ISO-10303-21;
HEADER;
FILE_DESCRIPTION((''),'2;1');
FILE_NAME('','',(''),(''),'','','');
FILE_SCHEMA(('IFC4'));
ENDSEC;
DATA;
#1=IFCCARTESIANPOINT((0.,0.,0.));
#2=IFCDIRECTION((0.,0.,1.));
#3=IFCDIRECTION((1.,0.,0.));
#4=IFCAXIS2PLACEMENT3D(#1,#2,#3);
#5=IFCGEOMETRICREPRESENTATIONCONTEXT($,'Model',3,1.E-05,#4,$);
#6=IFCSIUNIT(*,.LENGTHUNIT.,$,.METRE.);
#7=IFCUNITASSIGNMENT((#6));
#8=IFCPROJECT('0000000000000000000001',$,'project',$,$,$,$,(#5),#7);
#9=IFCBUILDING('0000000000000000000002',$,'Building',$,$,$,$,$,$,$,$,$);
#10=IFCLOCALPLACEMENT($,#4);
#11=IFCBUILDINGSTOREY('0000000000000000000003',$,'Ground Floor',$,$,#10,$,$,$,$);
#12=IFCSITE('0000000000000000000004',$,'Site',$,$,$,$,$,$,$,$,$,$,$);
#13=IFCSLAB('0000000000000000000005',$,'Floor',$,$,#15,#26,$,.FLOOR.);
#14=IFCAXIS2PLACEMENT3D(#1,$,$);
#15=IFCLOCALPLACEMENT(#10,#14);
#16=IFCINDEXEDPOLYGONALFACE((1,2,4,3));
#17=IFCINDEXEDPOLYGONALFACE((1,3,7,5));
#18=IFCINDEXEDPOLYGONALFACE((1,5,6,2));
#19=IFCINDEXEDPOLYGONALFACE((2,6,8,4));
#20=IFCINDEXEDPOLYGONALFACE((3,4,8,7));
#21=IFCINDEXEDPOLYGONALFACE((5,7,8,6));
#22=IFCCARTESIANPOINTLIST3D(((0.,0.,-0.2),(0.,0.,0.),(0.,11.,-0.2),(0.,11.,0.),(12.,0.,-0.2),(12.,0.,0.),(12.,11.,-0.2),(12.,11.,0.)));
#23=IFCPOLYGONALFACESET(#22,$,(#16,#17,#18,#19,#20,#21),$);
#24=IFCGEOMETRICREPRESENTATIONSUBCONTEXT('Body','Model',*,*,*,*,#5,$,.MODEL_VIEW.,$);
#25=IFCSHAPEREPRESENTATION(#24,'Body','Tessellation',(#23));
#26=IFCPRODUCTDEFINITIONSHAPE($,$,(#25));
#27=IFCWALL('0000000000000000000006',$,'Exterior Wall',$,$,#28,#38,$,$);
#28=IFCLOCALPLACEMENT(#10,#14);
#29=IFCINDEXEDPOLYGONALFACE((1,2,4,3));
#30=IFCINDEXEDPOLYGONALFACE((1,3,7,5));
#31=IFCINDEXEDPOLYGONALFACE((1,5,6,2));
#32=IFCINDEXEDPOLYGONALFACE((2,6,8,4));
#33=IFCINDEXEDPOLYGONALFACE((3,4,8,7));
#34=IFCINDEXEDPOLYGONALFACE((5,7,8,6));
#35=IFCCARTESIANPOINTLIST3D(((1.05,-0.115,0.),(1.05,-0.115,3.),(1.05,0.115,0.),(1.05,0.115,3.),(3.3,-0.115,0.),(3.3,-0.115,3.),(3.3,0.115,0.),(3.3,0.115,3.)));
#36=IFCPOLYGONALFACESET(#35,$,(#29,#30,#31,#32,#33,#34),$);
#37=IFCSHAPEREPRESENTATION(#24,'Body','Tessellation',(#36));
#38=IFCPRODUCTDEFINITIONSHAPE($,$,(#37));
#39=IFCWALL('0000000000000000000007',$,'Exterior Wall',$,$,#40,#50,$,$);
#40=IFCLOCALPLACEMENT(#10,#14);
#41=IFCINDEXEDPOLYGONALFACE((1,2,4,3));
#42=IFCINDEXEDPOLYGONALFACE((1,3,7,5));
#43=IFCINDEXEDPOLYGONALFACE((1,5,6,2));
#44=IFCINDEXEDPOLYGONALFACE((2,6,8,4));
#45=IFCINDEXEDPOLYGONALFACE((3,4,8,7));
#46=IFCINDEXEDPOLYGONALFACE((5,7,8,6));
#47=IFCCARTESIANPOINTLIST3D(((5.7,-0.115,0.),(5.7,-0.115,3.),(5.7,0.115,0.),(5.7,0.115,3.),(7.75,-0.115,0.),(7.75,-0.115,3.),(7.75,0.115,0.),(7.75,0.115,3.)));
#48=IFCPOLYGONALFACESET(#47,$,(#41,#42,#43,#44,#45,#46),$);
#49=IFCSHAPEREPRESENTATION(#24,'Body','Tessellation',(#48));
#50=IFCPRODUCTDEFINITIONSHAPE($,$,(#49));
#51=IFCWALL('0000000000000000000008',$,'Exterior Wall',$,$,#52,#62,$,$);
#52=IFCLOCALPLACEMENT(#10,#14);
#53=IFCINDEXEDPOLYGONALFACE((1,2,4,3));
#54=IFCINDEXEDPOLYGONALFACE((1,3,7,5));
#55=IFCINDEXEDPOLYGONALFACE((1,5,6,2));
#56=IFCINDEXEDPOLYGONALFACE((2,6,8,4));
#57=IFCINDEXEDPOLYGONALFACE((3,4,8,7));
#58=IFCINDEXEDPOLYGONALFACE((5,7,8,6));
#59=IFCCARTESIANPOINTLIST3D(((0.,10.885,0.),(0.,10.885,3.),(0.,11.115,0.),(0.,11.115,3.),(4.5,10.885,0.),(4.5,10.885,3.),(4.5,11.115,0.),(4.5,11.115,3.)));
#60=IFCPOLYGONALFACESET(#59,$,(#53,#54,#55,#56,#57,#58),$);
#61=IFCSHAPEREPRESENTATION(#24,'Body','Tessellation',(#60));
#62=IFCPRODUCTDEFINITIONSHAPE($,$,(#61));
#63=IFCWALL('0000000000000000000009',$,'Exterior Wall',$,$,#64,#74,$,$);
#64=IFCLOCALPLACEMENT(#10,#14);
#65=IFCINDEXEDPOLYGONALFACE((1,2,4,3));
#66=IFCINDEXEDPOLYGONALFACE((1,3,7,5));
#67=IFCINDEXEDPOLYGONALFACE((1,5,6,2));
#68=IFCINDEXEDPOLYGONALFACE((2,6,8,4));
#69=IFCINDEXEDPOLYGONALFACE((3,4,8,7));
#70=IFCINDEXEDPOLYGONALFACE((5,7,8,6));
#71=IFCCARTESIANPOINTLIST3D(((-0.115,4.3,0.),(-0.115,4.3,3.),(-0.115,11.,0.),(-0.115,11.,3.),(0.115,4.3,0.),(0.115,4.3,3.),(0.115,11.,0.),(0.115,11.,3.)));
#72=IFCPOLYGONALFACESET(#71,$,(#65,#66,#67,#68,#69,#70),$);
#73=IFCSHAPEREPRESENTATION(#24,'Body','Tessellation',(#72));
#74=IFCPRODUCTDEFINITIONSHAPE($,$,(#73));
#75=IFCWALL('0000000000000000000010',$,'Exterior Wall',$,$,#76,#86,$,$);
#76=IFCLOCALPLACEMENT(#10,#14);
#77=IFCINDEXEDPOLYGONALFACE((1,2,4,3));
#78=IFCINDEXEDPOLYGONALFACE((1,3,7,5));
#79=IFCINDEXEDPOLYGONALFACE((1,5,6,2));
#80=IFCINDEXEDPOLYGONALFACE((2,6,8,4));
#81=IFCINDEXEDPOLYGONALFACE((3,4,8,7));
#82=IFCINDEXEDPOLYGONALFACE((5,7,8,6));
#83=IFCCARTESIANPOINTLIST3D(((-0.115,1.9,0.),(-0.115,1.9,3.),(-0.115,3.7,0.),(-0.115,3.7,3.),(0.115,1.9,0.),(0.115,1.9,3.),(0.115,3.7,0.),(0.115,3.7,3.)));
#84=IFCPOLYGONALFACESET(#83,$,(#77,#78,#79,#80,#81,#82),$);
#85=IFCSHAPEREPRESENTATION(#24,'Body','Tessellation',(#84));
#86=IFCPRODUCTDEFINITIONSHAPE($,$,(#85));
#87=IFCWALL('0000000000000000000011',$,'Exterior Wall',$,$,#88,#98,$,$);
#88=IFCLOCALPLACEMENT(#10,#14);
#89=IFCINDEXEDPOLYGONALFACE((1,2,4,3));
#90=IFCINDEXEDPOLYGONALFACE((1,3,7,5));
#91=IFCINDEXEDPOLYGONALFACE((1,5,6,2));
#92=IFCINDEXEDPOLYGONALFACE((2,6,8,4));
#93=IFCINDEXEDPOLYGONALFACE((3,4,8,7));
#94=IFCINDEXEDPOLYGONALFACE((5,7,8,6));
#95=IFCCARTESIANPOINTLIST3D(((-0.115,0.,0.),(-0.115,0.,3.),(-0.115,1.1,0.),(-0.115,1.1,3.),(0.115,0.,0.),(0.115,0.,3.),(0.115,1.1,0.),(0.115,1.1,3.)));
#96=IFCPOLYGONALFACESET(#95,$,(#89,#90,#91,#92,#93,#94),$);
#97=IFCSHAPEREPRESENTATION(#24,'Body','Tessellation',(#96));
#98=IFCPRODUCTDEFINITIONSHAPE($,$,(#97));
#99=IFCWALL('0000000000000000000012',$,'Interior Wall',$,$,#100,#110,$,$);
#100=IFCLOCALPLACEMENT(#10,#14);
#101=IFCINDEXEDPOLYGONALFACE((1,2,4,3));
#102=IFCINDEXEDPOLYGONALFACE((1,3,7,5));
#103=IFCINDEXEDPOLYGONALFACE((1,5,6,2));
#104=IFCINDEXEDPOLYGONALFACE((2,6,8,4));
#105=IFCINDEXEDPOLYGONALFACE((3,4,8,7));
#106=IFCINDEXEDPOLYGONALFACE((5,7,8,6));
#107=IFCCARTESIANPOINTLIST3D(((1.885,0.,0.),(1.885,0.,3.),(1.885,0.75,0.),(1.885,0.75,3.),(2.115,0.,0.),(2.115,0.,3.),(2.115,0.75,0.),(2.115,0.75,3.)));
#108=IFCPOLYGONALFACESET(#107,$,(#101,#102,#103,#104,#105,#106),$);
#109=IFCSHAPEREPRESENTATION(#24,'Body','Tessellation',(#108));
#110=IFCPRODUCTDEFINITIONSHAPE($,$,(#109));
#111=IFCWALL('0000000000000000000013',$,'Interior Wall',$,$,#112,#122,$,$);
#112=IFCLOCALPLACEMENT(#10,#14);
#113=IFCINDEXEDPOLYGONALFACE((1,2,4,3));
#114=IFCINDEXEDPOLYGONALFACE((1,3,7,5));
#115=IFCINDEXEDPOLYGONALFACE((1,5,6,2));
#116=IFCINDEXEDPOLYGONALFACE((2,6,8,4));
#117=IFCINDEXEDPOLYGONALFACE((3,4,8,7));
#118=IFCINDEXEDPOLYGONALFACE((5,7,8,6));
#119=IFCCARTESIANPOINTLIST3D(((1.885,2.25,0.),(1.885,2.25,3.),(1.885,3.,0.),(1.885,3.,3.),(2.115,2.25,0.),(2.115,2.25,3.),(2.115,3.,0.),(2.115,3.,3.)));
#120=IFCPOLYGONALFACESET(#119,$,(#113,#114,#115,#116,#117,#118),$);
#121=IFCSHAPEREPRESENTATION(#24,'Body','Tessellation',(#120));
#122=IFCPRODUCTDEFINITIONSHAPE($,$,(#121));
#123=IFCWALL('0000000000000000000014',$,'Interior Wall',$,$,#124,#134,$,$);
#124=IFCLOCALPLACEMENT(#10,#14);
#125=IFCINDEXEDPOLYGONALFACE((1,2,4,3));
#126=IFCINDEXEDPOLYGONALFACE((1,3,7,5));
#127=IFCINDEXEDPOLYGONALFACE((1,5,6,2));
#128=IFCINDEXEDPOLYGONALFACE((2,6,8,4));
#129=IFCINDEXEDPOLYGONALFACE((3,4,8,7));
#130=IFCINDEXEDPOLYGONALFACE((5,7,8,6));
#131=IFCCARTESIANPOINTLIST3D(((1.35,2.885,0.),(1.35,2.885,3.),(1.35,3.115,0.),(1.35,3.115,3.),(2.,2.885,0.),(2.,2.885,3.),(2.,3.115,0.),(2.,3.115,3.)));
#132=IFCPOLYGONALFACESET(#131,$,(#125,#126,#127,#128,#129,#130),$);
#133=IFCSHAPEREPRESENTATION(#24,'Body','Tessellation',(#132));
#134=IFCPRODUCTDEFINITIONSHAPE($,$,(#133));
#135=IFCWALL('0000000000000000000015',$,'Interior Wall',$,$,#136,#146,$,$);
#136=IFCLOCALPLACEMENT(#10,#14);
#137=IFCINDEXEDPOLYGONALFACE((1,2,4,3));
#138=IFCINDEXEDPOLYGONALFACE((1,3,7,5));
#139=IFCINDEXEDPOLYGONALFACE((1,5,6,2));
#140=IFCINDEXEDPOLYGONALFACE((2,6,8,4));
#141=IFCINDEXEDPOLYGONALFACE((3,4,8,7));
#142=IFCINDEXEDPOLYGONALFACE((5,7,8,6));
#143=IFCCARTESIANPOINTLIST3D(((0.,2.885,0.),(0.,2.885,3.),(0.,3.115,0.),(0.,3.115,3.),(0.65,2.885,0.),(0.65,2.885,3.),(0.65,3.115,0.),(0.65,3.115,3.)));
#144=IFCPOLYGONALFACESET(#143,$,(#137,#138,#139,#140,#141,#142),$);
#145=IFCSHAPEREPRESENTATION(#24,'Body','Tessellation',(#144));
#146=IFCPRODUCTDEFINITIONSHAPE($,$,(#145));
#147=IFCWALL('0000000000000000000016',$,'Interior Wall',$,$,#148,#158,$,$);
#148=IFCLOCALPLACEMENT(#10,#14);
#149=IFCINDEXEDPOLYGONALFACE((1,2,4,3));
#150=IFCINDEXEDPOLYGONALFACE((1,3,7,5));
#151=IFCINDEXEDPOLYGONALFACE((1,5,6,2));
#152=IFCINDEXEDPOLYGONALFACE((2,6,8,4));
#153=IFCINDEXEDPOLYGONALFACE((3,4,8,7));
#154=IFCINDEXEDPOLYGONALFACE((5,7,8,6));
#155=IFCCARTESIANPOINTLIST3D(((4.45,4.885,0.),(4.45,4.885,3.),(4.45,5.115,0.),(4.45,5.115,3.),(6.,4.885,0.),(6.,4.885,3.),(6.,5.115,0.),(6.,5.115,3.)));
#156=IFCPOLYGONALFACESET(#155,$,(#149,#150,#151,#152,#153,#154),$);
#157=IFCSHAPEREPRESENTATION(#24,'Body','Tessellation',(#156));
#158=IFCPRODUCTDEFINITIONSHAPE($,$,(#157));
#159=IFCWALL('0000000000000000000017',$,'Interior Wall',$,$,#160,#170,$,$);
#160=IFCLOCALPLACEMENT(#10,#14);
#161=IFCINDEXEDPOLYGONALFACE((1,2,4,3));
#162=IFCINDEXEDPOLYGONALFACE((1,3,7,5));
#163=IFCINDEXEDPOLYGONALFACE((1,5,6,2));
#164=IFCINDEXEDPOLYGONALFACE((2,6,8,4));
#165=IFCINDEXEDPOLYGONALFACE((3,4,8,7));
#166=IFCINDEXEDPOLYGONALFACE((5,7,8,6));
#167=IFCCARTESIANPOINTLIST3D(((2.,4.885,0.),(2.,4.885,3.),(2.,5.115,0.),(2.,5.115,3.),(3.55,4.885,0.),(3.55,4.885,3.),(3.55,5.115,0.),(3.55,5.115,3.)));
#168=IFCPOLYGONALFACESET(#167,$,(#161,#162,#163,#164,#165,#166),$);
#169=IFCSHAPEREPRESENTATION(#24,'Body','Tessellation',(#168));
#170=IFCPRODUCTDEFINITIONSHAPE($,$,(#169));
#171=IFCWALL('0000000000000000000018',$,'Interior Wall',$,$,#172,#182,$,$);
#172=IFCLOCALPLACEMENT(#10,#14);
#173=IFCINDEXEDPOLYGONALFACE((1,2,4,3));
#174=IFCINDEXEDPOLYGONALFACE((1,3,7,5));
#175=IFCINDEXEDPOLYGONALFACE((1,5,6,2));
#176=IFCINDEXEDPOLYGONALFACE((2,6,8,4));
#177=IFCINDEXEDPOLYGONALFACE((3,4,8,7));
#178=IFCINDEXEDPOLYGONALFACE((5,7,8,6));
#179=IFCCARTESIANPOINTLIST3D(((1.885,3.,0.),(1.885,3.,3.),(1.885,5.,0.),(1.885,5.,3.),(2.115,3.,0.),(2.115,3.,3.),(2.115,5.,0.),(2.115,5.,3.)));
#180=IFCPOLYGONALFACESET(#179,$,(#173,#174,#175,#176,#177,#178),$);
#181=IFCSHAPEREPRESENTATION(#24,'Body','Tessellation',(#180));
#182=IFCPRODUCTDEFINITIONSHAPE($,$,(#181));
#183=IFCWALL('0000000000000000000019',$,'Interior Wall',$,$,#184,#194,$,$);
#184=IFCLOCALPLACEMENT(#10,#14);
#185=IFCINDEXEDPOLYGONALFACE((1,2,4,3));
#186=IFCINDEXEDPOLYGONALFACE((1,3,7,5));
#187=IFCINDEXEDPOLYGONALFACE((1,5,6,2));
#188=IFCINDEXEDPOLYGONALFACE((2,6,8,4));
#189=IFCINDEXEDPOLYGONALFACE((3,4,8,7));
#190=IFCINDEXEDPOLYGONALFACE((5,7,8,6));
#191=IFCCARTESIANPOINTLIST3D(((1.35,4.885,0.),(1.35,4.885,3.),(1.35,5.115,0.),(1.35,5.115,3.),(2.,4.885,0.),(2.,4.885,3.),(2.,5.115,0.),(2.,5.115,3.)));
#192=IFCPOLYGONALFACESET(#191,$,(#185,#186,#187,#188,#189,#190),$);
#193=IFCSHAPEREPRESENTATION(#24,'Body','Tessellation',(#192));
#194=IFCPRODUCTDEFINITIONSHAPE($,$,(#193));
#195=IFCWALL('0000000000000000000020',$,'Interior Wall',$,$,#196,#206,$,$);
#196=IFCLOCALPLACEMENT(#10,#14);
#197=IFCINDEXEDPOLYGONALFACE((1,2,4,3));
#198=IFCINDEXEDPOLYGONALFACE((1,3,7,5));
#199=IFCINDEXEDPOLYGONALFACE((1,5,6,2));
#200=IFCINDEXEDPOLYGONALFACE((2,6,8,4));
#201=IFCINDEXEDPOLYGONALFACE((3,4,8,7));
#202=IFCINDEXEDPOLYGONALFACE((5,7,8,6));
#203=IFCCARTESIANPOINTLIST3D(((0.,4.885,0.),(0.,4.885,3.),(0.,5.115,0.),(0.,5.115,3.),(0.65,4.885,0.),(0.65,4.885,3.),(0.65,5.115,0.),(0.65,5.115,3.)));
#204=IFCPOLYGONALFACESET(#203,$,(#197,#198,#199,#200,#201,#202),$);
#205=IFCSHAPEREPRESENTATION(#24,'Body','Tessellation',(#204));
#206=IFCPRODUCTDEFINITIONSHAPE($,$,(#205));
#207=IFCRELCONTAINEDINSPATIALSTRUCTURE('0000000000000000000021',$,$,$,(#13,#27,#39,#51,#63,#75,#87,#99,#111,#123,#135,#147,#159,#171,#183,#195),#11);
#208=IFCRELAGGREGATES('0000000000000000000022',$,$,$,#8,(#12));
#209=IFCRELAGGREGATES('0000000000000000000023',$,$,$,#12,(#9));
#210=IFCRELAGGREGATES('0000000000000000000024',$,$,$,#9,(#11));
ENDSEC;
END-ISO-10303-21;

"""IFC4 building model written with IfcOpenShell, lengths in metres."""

from ifc_helpers import new_model, si_unit, frame, origin_with_axes, place, context, subcontext, project, spatial, indexed_curve, outline, extrude, element, save


model = new_model("IFC4")

# Units and contexts
model_context = context("Model", 3, precision=1e-05, world=origin_with_axes())
body_context = subcontext(model_context, "Body", "Model", "MODEL_VIEW")
ifc_project = project(units=[si_unit("LENGTHUNIT", "METRE")], contexts=[model_context])

# Site, building, storey
site = spatial("IfcSite", under=ifc_project, Name="Site")
building = spatial("IfcBuilding", under=site, Name="Building")
storey_placement = place(None, origin_with_axes())
storey = spatial("IfcBuildingStorey", under=building, at=storey_placement, Name="Ground Floor")

# Slab
slab_placement = place(storey_placement, frame((0.0, 0.0, -0.2), z_axis=(0.0, 0.0, 1.0), x_axis=(1.0, 0.0, 0.0)))
element("IfcSlab", 1, at=slab_placement, inside=storey, Name="Floor", PredefinedType="FLOOR", context=body_context, shape_type="SweptSolid", body=[
    extrude(outline(indexed_curve([(0.0, 0.0), (12.0, 0.0), (12.0, 11.0), (0.0, 11.0)])), None, (0.0, 0.0, 1.0), 0.2),
])

# Walls
wall_1_placement = place(storey_placement, frame((1.05, 0.0, 0.0), z_axis=(0.0, 0.0, 1.0), x_axis=(1.0, 0.0, 0.0)))
element("IfcWall", 2, at=wall_1_placement, inside=storey, Name="Exterior Wall", context=body_context, shape_type="SweptSolid", body=[
    extrude(outline(indexed_curve([(0.0, 0.0), (0.0, 0.23), (2.25, 0.23), (2.25, 0.0), (0.0, 0.0)], self_intersect=False)), frame((0.0, -0.115, 0.0), z_axis=(0.0, 0.0, 1.0), x_axis=(1.0, 0.0, 0.0)), (0.0, 0.0, 1.0), 3.0),
])
wall_2_placement = place(storey_placement, frame((5.7, 0.0, 0.0), z_axis=(0.0, 0.0, 1.0), x_axis=(1.0, 0.0, 0.0)))
element("IfcWall", 3, at=wall_2_placement, inside=storey, Name="Exterior Wall", context=body_context, shape_type="SweptSolid", body=[
    extrude(outline(indexed_curve([(0.0, 0.0), (0.0, 0.23), (2.05, 0.23), (2.05, 0.0), (0.0, 0.0)], self_intersect=False)), frame((0.0, -0.115, 0.0), z_axis=(0.0, 0.0, 1.0), x_axis=(1.0, 0.0, 0.0)), (0.0, 0.0, 1.0), 3.0),
])
wall_3_placement = place(storey_placement, frame((4.5, 11.0, 0.0), z_axis=(0.0, 0.0, 1.0), x_axis=(-1.0, 0.0, 0.0)))
element("IfcWall", 4, at=wall_3_placement, inside=storey, Name="Exterior Wall", context=body_context, shape_type="SweptSolid", body=[
    extrude(outline(indexed_curve([(0.0, 0.0), (0.0, 0.23), (4.5, 0.23), (4.5, 0.0), (0.0, 0.0)], self_intersect=False)), frame((0.0, -0.115, 0.0), z_axis=(0.0, 0.0, 1.0), x_axis=(1.0, 0.0, 0.0)), (0.0, 0.0, 1.0), 3.0),
])
wall_4_placement = place(storey_placement, frame((0.0, 11.0, 0.0), z_axis=(0.0, 0.0, 1.0), x_axis=(0.0, -1.0, 0.0)))
element("IfcWall", 5, at=wall_4_placement, inside=storey, Name="Exterior Wall", context=body_context, shape_type="SweptSolid", body=[
    extrude(outline(indexed_curve([(0.0, 0.0), (0.0, 0.23), (6.7, 0.23), (6.7, 0.0), (0.0, 0.0)], self_intersect=False)), frame((0.0, -0.115, 0.0), z_axis=(0.0, 0.0, 1.0), x_axis=(1.0, 0.0, 0.0)), (0.0, 0.0, 1.0), 3.0),
])
wall_5_placement = place(storey_placement, frame((0.0, 3.7, 0.0), z_axis=(0.0, 0.0, 1.0), x_axis=(0.0, -1.0, 0.0)))
element("IfcWall", 6, at=wall_5_placement, inside=storey, Name="Exterior Wall", context=body_context, shape_type="SweptSolid", body=[
    extrude(outline(indexed_curve([(0.0, 0.0), (0.0, 0.23), (1.8, 0.23), (1.8, 0.0), (0.0, 0.0)], self_intersect=False)), frame((0.0, -0.115, 0.0), z_axis=(0.0, 0.0, 1.0), x_axis=(1.0, 0.0, 0.0)), (0.0, 0.0, 1.0), 3.0),
])
wall_6_placement = place(storey_placement, frame((0.0, 1.1, 0.0), z_axis=(0.0, 0.0, 1.0), x_axis=(0.0, -1.0, 0.0)))
element("IfcWall", 7, at=wall_6_placement, inside=storey, Name="Exterior Wall", context=body_context, shape_type="SweptSolid", body=[
    extrude(outline(indexed_curve([(0.0, 0.0), (0.0, 0.23), (1.1, 0.23), (1.1, 0.0), (0.0, 0.0)], self_intersect=False)), frame((0.0, -0.115, 0.0), z_axis=(0.0, 0.0, 1.0), x_axis=(1.0, 0.0, 0.0)), (0.0, 0.0, 1.0), 3.0),
])
for number, where, z_axis, x_axis, name in (
    (8, (2.0, 0.0, 0.0), (0.0, 0.0, 1.0), (0.0, 1.0, 0.0), "Interior Wall"),
    (9, (2.0, 2.25, 0.0), (0.0, 0.0, 1.0), (0.0, 1.0, 0.0), "Interior Wall"),
):
    element("IfcWall", number, at=place(storey_placement, frame(where, z_axis=z_axis, x_axis=x_axis)), inside=storey, Name=name, context=body_context, shape_type="SweptSolid", body=[
        extrude(outline(indexed_curve([(0.0, 0.0), (0.0, 0.23), (0.75, 0.23), (0.75, 0.0), (0.0, 0.0)], self_intersect=False)), frame((0.0, -0.115, 0.0), z_axis=(0.0, 0.0, 1.0), x_axis=(1.0, 0.0, 0.0)), (0.0, 0.0, 1.0), 3.0),
    ])
for number, where, z_axis, x_axis, name in (
    (10, (2.0, 3.0, 0.0), (0.0, 0.0, 1.0), (-1.0, 0.0, 0.0), "Interior Wall"),
    (11, (0.65, 3.0, 0.0), (0.0, 0.0, 1.0), (-1.0, 0.0, 0.0), "Interior Wall"),
):
    element("IfcWall", number, at=place(storey_placement, frame(where, z_axis=z_axis, x_axis=x_axis)), inside=storey, Name=name, context=body_context, shape_type="SweptSolid", body=[
        extrude(outline(indexed_curve([(0.0, 0.0), (0.0, 0.23), (0.65, 0.23), (0.65, 0.0), (0.0, 0.0)], self_intersect=False)), frame((0.0, -0.115, 0.0), z_axis=(0.0, 0.0, 1.0), x_axis=(1.0, 0.0, 0.0)), (0.0, 0.0, 1.0), 3.0),
    ])
for number, where, z_axis, x_axis, name in (
    (12, (6.0, 5.0, 0.0), (0.0, 0.0, 1.0), (-1.0, 0.0, 0.0), "Interior Wall"),
    (13, (3.55, 5.0, 0.0), (0.0, 0.0, 1.0), (-1.0, 0.0, 0.0), "Interior Wall"),
):
    element("IfcWall", number, at=place(storey_placement, frame(where, z_axis=z_axis, x_axis=x_axis)), inside=storey, Name=name, context=body_context, shape_type="SweptSolid", body=[
        extrude(outline(indexed_curve([(0.0, 0.0), (0.0, 0.23), (1.55, 0.23), (1.55, 0.0), (0.0, 0.0)], self_intersect=False)), frame((0.0, -0.115, 0.0), z_axis=(0.0, 0.0, 1.0), x_axis=(1.0, 0.0, 0.0)), (0.0, 0.0, 1.0), 3.0),
    ])
wall_7_placement = place(storey_placement, frame((2.0, 5.0, 0.0), z_axis=(0.0, 0.0, 1.0), x_axis=(0.0, -1.0, 0.0)))
element("IfcWall", 14, at=wall_7_placement, inside=storey, Name="Interior Wall", context=body_context, shape_type="SweptSolid", body=[
    extrude(outline(indexed_curve([(0.0, 0.0), (0.0, 0.23), (2.0, 0.23), (2.0, 0.0), (0.0, 0.0)], self_intersect=False)), frame((0.0, -0.115, 0.0), z_axis=(0.0, 0.0, 1.0), x_axis=(1.0, 0.0, 0.0)), (0.0, 0.0, 1.0), 3.0),
])
for number, where, z_axis, x_axis, name in (
    (15, (2.0, 5.0, 0.0), (0.0, 0.0, 1.0), (-1.0, 0.0, 0.0), "Interior Wall"),
    (16, (0.65, 5.0, 0.0), (0.0, 0.0, 1.0), (-1.0, 0.0, 0.0), "Interior Wall"),
):
    element("IfcWall", number, at=place(storey_placement, frame(where, z_axis=z_axis, x_axis=x_axis)), inside=storey, Name=name, context=body_context, shape_type="SweptSolid", body=[
        extrude(outline(indexed_curve([(0.0, 0.0), (0.0, 0.23), (0.65, 0.23), (0.65, 0.0), (0.0, 0.0)], self_intersect=False)), frame((0.0, -0.115, 0.0), z_axis=(0.0, 0.0, 1.0), x_axis=(1.0, 0.0, 0.0)), (0.0, 0.0, 1.0), 3.0),
    ])

save(model, "model.ifc")
